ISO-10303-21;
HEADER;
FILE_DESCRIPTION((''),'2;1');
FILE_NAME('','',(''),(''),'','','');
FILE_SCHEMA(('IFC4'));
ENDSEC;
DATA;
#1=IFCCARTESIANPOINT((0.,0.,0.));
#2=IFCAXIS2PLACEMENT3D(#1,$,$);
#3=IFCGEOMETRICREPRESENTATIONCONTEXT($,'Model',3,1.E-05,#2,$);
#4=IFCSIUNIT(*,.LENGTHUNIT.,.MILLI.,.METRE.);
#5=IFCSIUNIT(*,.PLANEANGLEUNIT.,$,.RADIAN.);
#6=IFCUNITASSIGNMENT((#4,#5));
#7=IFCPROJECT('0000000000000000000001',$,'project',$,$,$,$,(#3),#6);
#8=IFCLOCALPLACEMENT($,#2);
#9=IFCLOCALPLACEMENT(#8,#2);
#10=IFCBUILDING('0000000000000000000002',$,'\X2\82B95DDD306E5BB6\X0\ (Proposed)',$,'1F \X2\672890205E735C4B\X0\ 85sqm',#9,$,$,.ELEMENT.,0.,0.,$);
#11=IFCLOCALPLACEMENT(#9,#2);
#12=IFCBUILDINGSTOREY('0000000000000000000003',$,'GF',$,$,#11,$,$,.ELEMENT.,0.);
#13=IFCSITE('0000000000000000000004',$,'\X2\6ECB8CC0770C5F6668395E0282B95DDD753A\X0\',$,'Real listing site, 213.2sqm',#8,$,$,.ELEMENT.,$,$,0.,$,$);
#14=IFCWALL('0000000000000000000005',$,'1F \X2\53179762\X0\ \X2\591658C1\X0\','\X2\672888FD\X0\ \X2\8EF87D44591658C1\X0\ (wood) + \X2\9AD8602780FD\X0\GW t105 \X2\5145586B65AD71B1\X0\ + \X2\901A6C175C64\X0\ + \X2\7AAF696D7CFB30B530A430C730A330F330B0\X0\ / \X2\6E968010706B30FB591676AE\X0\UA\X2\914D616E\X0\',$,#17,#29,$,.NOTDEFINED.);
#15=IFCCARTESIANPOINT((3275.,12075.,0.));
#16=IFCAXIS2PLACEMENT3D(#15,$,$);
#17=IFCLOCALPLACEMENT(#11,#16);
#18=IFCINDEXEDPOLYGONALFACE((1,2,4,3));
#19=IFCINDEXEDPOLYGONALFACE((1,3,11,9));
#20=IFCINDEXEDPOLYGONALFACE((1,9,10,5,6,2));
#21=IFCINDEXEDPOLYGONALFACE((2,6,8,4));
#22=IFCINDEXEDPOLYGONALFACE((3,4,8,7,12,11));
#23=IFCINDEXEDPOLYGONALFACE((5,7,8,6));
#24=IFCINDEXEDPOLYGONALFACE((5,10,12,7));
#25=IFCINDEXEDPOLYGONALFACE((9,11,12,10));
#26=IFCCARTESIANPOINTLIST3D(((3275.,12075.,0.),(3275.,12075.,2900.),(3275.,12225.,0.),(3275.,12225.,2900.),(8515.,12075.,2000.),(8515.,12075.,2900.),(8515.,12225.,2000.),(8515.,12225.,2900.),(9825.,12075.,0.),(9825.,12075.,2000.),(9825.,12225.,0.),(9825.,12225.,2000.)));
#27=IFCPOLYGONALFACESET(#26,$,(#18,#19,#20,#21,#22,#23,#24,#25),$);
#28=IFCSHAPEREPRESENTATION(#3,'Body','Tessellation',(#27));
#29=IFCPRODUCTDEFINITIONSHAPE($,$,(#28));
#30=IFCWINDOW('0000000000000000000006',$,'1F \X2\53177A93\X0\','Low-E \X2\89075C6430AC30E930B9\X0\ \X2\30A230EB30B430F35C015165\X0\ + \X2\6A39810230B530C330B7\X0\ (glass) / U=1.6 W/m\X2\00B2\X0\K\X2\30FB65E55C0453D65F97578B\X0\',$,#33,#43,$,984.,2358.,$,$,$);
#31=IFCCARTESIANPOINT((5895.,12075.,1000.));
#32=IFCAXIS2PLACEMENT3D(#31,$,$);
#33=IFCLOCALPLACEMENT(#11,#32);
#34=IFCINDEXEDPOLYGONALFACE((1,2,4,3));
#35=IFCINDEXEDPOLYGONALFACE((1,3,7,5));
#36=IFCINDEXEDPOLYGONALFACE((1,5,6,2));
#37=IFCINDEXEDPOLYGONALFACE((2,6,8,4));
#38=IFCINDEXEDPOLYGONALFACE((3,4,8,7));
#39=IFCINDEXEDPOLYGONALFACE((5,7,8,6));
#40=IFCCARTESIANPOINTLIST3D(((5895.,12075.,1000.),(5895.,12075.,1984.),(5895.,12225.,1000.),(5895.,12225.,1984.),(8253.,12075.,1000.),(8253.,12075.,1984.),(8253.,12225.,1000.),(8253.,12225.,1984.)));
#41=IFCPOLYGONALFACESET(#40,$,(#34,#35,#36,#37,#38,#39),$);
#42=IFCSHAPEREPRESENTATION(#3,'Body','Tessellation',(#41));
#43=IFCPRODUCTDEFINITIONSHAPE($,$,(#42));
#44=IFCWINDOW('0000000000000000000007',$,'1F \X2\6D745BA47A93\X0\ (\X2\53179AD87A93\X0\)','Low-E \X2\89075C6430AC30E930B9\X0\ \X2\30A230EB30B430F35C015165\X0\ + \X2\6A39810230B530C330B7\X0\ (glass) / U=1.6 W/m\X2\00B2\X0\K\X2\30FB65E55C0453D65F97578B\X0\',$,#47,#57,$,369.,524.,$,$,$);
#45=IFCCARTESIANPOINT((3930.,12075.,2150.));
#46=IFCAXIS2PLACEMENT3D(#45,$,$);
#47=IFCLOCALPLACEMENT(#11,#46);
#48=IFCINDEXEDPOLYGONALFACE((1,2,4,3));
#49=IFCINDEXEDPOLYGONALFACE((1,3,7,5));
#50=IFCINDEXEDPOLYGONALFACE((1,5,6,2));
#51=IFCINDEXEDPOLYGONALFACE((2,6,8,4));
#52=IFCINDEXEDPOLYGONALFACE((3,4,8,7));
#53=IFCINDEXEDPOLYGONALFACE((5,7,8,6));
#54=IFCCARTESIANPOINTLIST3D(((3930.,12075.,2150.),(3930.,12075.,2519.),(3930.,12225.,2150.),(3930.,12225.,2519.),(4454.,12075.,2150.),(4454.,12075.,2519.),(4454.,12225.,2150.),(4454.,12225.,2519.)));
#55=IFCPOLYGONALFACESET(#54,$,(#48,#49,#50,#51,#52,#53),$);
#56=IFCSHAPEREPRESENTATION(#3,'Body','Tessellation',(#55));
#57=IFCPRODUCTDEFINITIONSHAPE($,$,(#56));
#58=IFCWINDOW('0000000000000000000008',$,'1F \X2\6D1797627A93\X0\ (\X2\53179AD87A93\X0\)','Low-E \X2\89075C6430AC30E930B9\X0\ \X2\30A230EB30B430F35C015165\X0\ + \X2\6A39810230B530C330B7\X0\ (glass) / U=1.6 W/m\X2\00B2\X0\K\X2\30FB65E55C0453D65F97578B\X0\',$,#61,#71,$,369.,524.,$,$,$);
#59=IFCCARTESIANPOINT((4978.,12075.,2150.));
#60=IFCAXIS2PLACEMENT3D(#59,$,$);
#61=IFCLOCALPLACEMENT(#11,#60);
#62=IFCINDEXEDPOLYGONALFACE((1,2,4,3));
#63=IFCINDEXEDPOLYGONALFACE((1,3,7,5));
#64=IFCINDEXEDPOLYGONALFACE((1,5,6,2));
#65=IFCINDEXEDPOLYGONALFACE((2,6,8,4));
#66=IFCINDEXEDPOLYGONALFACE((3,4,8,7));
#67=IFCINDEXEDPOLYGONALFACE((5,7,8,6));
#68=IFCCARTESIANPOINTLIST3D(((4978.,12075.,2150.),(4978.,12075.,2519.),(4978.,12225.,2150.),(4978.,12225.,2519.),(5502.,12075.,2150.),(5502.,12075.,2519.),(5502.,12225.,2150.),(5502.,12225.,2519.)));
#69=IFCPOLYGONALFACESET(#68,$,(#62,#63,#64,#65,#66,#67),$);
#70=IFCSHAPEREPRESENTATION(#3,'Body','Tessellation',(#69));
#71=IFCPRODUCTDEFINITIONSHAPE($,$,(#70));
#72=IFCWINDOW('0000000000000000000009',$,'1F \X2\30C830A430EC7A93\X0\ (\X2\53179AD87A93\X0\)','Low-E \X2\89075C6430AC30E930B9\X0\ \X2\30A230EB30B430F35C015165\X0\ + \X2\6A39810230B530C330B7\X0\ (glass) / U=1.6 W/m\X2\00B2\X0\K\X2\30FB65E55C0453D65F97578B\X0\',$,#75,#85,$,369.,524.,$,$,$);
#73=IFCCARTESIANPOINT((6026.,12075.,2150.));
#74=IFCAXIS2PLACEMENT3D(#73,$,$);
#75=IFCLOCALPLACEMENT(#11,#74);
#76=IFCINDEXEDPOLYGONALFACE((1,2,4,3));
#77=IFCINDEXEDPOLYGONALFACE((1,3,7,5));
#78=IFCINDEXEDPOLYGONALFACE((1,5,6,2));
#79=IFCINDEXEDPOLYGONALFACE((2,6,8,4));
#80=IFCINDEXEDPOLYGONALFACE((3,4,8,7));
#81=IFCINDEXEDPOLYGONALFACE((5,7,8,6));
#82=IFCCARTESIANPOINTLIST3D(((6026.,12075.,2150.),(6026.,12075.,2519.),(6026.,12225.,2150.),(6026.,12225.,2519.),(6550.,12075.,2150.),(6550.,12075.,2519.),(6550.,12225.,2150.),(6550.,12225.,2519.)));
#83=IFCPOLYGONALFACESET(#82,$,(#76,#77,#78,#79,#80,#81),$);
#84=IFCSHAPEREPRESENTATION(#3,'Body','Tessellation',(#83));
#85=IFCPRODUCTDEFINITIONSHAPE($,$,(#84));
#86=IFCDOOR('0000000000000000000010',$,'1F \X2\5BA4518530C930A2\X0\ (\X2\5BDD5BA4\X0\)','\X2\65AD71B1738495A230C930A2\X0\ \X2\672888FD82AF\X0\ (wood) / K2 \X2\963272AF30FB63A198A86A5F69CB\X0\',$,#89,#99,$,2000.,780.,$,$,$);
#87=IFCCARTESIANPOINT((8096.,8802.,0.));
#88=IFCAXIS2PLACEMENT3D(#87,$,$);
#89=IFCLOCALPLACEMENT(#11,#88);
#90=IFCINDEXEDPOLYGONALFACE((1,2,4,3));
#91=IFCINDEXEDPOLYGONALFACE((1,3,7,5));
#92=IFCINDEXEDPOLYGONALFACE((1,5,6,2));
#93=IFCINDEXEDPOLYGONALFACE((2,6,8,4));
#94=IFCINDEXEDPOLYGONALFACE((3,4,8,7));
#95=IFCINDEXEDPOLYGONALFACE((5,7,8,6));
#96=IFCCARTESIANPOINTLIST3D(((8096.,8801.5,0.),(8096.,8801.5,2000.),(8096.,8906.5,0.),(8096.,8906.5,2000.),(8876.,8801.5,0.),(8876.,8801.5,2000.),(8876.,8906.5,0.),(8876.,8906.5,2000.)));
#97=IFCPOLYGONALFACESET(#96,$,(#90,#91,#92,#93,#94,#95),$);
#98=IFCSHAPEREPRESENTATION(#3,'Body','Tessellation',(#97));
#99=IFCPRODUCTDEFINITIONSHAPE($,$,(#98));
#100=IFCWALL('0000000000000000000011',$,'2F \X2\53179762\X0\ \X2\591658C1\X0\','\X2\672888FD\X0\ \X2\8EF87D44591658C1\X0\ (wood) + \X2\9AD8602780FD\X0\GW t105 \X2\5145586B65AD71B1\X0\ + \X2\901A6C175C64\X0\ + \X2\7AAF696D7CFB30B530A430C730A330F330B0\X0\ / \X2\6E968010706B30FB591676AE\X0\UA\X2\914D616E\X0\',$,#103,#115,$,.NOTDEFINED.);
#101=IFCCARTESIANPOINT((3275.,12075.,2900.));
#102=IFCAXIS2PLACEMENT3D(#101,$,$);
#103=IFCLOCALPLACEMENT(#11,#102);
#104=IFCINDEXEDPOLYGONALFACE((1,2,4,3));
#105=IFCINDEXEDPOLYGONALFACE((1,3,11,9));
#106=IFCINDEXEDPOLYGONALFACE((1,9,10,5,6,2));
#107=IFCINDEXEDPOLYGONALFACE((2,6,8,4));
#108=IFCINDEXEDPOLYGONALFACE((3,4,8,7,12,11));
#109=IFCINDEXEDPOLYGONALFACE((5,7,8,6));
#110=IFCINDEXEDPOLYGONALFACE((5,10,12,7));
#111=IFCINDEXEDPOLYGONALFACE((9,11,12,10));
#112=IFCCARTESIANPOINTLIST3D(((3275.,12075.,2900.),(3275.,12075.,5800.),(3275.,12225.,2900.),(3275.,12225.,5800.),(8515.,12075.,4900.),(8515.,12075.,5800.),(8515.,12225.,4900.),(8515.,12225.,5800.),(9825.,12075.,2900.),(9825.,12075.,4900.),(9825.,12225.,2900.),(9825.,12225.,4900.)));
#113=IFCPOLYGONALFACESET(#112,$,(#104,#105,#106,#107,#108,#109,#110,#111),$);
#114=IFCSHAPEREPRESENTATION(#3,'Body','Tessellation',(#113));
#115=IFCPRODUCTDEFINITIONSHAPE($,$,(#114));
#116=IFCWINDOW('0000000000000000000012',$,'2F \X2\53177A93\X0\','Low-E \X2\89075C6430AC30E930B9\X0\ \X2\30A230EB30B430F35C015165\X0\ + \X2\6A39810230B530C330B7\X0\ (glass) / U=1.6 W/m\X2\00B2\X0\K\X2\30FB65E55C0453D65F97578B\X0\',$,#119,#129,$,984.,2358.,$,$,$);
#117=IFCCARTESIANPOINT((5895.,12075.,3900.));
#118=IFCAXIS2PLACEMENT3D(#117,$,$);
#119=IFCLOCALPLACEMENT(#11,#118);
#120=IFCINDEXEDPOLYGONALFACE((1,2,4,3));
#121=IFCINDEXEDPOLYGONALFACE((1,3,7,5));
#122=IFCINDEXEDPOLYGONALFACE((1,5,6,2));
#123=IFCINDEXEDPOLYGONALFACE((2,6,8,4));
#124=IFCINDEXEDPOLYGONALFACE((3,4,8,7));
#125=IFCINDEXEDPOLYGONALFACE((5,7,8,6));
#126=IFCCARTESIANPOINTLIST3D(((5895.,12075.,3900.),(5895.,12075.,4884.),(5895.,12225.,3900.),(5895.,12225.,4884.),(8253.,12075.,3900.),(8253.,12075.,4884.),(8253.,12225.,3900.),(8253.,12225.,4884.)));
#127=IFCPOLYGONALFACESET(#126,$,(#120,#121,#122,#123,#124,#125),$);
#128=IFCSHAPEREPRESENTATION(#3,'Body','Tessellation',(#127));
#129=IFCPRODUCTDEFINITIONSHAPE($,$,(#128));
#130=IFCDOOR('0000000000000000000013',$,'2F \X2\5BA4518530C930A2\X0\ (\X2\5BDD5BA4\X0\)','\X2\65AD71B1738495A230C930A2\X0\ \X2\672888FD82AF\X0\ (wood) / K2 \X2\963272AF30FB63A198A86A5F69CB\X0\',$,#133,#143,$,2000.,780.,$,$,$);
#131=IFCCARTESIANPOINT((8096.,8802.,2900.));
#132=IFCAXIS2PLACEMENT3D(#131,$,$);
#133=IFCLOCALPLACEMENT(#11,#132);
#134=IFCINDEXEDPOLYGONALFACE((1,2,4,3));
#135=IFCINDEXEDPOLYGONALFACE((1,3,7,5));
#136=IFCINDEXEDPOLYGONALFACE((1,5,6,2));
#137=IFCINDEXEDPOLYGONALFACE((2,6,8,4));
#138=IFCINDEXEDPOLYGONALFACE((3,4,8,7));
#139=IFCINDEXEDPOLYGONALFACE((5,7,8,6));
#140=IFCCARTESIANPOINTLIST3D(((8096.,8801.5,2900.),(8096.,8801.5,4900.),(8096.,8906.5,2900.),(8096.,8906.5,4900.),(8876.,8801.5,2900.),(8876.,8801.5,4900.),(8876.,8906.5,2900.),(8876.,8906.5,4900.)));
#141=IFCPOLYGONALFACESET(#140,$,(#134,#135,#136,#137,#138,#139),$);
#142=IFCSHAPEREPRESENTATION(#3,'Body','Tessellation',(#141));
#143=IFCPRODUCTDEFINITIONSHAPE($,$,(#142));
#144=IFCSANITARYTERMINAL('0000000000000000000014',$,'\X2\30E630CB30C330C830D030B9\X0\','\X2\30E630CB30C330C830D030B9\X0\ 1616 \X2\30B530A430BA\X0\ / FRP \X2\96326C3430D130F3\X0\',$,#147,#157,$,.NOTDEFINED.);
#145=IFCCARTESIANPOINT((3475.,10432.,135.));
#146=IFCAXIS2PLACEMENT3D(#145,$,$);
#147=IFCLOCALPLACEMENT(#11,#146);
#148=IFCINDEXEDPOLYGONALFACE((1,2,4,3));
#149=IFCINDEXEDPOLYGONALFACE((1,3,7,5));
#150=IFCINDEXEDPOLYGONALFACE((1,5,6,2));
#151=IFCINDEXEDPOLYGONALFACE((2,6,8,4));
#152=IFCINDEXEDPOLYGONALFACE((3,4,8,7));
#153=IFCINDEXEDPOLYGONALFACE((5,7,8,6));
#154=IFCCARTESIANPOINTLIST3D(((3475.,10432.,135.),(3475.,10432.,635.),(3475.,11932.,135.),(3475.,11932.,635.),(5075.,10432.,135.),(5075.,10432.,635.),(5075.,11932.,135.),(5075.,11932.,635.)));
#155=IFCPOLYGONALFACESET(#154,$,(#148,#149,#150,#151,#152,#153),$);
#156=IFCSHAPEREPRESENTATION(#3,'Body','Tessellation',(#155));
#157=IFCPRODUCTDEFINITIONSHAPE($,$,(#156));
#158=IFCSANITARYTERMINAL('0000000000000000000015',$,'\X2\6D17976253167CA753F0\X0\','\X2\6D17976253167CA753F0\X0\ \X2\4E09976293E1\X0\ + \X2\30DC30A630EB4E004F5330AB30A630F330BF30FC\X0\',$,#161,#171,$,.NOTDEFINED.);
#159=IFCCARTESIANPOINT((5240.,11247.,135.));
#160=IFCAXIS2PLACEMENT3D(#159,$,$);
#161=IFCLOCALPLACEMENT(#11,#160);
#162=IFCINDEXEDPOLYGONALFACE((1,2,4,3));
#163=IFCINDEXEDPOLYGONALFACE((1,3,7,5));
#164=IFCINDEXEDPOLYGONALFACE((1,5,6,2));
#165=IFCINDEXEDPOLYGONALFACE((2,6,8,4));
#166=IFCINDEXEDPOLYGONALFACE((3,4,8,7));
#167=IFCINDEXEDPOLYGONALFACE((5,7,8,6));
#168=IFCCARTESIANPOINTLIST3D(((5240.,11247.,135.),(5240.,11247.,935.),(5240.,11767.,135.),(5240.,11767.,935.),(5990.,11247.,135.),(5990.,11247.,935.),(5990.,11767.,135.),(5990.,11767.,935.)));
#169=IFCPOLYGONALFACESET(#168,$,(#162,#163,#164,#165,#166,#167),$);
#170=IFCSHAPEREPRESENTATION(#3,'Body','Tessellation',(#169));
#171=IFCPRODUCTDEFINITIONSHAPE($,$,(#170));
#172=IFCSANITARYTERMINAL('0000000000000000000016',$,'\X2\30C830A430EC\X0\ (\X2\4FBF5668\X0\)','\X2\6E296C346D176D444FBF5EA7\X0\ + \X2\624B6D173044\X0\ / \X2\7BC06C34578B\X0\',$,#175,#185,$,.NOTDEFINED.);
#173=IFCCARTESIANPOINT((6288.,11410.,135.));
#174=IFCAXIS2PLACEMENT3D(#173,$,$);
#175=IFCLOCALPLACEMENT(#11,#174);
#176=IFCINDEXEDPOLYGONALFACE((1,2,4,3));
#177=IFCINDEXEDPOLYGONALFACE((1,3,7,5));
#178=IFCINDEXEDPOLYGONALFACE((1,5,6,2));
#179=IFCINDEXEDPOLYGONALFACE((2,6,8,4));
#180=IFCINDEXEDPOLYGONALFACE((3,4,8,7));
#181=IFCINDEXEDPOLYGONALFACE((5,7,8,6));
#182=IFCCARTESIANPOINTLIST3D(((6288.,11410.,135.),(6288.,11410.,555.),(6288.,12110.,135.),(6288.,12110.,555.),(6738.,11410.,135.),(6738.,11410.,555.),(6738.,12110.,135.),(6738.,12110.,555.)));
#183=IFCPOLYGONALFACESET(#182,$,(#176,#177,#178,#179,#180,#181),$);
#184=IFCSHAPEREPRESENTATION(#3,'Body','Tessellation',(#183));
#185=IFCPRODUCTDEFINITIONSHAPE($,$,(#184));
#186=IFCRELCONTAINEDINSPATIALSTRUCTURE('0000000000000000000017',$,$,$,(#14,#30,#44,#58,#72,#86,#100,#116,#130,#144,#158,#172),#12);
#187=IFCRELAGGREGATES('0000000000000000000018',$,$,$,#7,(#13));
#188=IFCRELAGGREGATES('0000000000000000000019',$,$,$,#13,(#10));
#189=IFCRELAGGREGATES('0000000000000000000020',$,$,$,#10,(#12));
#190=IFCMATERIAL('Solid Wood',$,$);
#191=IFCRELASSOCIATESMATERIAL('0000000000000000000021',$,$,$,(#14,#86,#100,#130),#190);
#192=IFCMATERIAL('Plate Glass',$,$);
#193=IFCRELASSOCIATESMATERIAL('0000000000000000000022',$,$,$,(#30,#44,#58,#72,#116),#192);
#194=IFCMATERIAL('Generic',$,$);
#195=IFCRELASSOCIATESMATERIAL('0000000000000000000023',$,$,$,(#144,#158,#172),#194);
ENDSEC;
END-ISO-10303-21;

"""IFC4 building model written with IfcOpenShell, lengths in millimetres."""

from ifc_helpers import new_model, si_unit, frame, frame_2d, origin, place, context, project, spatial, rectangle, extrude, material, element, fill, save


model = new_model("IFC4")

# Units and contexts
model_context = context("Model", 3, precision=1e-05, world=origin())
ifc_project = project(units=[si_unit("LENGTHUNIT", "METRE", prefix="MILLI"), si_unit("PLANEANGLEUNIT", "RADIAN")], contexts=[model_context])

# Site, building, storey
site_placement = place(None, origin())
site = spatial("IfcSite", under=ifc_project, at=site_placement, Name="滋賀県彦根市芹川町", ObjectType="Real listing site, 213.2sqm", CompositionType="ELEMENT", RefElevation=0.0)
building_placement = place(site_placement, origin())
building = spatial("IfcBuilding", under=site, at=building_placement, Name="芹川の家 (Proposed)", ObjectType="1F 木造平屋 85sqm", CompositionType="ELEMENT", ElevationOfRefHeight=0.0, ElevationOfTerrain=0.0)
storey_placement = place(building_placement, origin())
storey = spatial("IfcBuildingStorey", under=building, at=storey_placement, Name="GF", CompositionType="ELEMENT", Elevation=0.0)

# Wall, openings, windows
ifc_material_1 = material(Name="Solid Wood")
wall_1_placement = place(storey_placement, frame((3275.0, 12075.0, 0.0)))
wall_1 = element("IfcWall", 1, at=wall_1_placement, inside=storey, material=ifc_material_1, Name="1F 北面 外壁", Description="木製 軸組外壁 (wood) + 高性能GW t105 充填断熱 + 通気層 + 窯業系サイディング / 準耐火・外皮UA配慮", PredefinedType="NOTDEFINED", context=model_context, shape_type="SweptSolid", body=[
    extrude(rectangle(XDim=6550.0, YDim=150.0, at=frame_2d((3275.0, 75.0))), frame((3275.0, 12075.0, 0.0)), (0.0, 0.0, 1.0), 2900.0),
])
opening_1_placement = place(storey_placement, frame((5895.0, 12075.0, 1000.0)))
opening_1 = element("IfcOpeningElement", 2, at=opening_1_placement, cuts=wall_1, PredefinedType="NOTDEFINED", context=model_context, shape_type="SweptSolid", body=[
    extrude(rectangle(XDim=2358.0, YDim=150.0, at=frame_2d((1179.0, 75.0))), frame((5895.0, 12075.0, 1000.0)), (0.0, 0.0, 1.0), 984.0),
])
opening_2_placement = place(storey_placement, frame((3930.0, 12075.0, 2150.0)))
opening_2 = element("IfcOpeningElement", 3, at=opening_2_placement, cuts=wall_1, PredefinedType="NOTDEFINED", context=model_context, shape_type="SweptSolid", body=[
    extrude(rectangle(XDim=524.0, YDim=150.0, at=frame_2d((262.0, 75.0))), frame((3930.0, 12075.0, 2150.0)), (0.0, 0.0, 1.0), 369.0),
])
opening_3_placement = place(storey_placement, frame((4978.0, 12075.0, 2150.0)))
opening_3 = element("IfcOpeningElement", 4, at=opening_3_placement, cuts=wall_1, PredefinedType="NOTDEFINED", context=model_context, shape_type="SweptSolid", body=[
    extrude(rectangle(XDim=524.0, YDim=150.0, at=frame_2d((262.0, 75.0))), frame((4978.0, 12075.0, 2150.0)), (0.0, 0.0, 1.0), 369.0),
])
opening_4_placement = place(storey_placement, frame((6026.0, 12075.0, 2150.0)))
opening_4 = element("IfcOpeningElement", 5, at=opening_4_placement, cuts=wall_1, PredefinedType="NOTDEFINED", context=model_context, shape_type="SweptSolid", body=[
    extrude(rectangle(XDim=524.0, YDim=150.0, at=frame_2d((262.0, 75.0))), frame((6026.0, 12075.0, 2150.0)), (0.0, 0.0, 1.0), 369.0),
])
ifc_material_2 = material(Name="Plate Glass")
window_1_placement = place(storey_placement, frame((5895.0, 12075.0, 1000.0)))
window_1 = element("IfcWindow", 6, at=window_1_placement, inside=storey, material=ifc_material_2, Name="1F 北窓", Description="Low-E 複層ガラス アルゴン封入 + 樹脂サッシ (glass) / U=1.6 W/m²K・日射取得型", OverallHeight=984.0, OverallWidth=2358.0, context=model_context, shape_type="SweptSolid", body=[
    extrude(rectangle(XDim=2358.0, YDim=150.0, at=frame_2d((1179.0, 75.0))), frame((5895.0, 12075.0, 1000.0)), (0.0, 0.0, 1.0), 984.0),
])
fill(opening_1, window_1)
window_2_placement = place(storey_placement, frame((3930.0, 12075.0, 2150.0)))
window_2 = element("IfcWindow", 7, at=window_2_placement, inside=storey, material=ifc_material_2, Name="1F 浴室窓 (北高窓)", Description="Low-E 複層ガラス アルゴン封入 + 樹脂サッシ (glass) / U=1.6 W/m²K・日射取得型", OverallHeight=369.0, OverallWidth=524.0, context=model_context, shape_type="SweptSolid", body=[
    extrude(rectangle(XDim=524.0, YDim=150.0, at=frame_2d((262.0, 75.0))), frame((3930.0, 12075.0, 2150.0)), (0.0, 0.0, 1.0), 369.0),
])
fill(opening_2, window_2)
window_3_placement = place(storey_placement, frame((4978.0, 12075.0, 2150.0)))
window_3 = element("IfcWindow", 8, at=window_3_placement, inside=storey, material=ifc_material_2, Name="1F 洗面窓 (北高窓)", Description="Low-E 複層ガラス アルゴン封入 + 樹脂サッシ (glass) / U=1.6 W/m²K・日射取得型", OverallHeight=369.0, OverallWidth=524.0, context=model_context, shape_type="SweptSolid", body=[
    extrude(rectangle(XDim=524.0, YDim=150.0, at=frame_2d((262.0, 75.0))), frame((4978.0, 12075.0, 2150.0)), (0.0, 0.0, 1.0), 369.0),
])
fill(opening_3, window_3)
window_4_placement = place(storey_placement, frame((6026.0, 12075.0, 2150.0)))
window_4 = element("IfcWindow", 9, at=window_4_placement, inside=storey, material=ifc_material_2, Name="1F トイレ窓 (北高窓)", Description="Low-E 複層ガラス アルゴン封入 + 樹脂サッシ (glass) / U=1.6 W/m²K・日射取得型", OverallHeight=369.0, OverallWidth=524.0, context=model_context, shape_type="SweptSolid", body=[
    extrude(rectangle(XDim=524.0, YDim=150.0, at=frame_2d((262.0, 75.0))), frame((6026.0, 12075.0, 2150.0)), (0.0, 0.0, 1.0), 369.0),
])
fill(opening_4, window_4)

# Door
door_1_placement = place(storey_placement, frame((8096.0, 8802.0, 0.0)))
element("IfcDoor", 10, at=door_1_placement, inside=storey, material=ifc_material_1, Name="1F 室内ドア (寝室)", Description="断熱玄関ドア 木製芯 (wood) / K2 防犯・採風機構", OverallHeight=2000.0, OverallWidth=780.0, context=model_context, shape_type="SweptSolid", body=[
    extrude(rectangle(XDim=780.0, YDim=105.0, at=frame_2d((390.0, 52.0))), frame((8096.0, 8802.0, 0.0)), (0.0, 0.0, 1.0), 2000.0),
])

# Wall, opening, window
wall_2_placement = place(storey_placement, frame((3275.0, 12075.0, 2900.0)))
wall_2 = element("IfcWall", 11, at=wall_2_placement, inside=storey, material=ifc_material_1, Name="2F 北面 外壁", Description="木製 軸組外壁 (wood) + 高性能GW t105 充填断熱 + 通気層 + 窯業系サイディング / 準耐火・外皮UA配慮", PredefinedType="NOTDEFINED", context=model_context, shape_type="SweptSolid", body=[
    extrude(rectangle(XDim=6550.0, YDim=150.0, at=frame_2d((3275.0, 75.0))), frame((3275.0, 12075.0, 2900.0)), (0.0, 0.0, 1.0), 2900.0),
])
opening_5_placement = place(storey_placement, frame((5895.0, 12075.0, 3900.0)))
opening_5 = element("IfcOpeningElement", 12, at=opening_5_placement, cuts=wall_2, PredefinedType="NOTDEFINED", context=model_context, shape_type="SweptSolid", body=[
    extrude(rectangle(XDim=2358.0, YDim=150.0, at=frame_2d((1179.0, 75.0))), frame((5895.0, 12075.0, 3900.0)), (0.0, 0.0, 1.0), 984.0),
])
window_5_placement = place(storey_placement, frame((5895.0, 12075.0, 3900.0)))
window_5 = element("IfcWindow", 13, at=window_5_placement, inside=storey, material=ifc_material_2, Name="2F 北窓", Description="Low-E 複層ガラス アルゴン封入 + 樹脂サッシ (glass) / U=1.6 W/m²K・日射取得型", OverallHeight=984.0, OverallWidth=2358.0, context=model_context, shape_type="SweptSolid", body=[
    extrude(rectangle(XDim=2358.0, YDim=150.0, at=frame_2d((1179.0, 75.0))), frame((5895.0, 12075.0, 3900.0)), (0.0, 0.0, 1.0), 984.0),
])
fill(opening_5, window_5)

# Door
door_2_placement = place(storey_placement, frame((8096.0, 8802.0, 2900.0)))
element("IfcDoor", 14, at=door_2_placement, inside=storey, material=ifc_material_1, Name="2F 室内ドア (寝室)", Description="断熱玄関ドア 木製芯 (wood) / K2 防犯・採風機構", OverallHeight=2000.0, OverallWidth=780.0, context=model_context, shape_type="SweptSolid", body=[
    extrude(rectangle(XDim=780.0, YDim=105.0, at=frame_2d((390.0, 52.0))), frame((8096.0, 8802.0, 2900.0)), (0.0, 0.0, 1.0), 2000.0),
])

# Sanitary terminals
ifc_material_3 = material(Name="Generic")
sanitary_terminal_1_placement = place(storey_placement, frame((3475.0, 10432.0, 135.0)))
element("IfcSanitaryTerminal", 15, at=sanitary_terminal_1_placement, inside=storey, material=ifc_material_3, Name="ユニットバス", Description="ユニットバス 1616 サイズ / FRP 防水パン", PredefinedType="NOTDEFINED", context=model_context, shape_type="SweptSolid", body=[
    extrude(rectangle(XDim=1600.0, YDim=1500.0, at=frame_2d((800.0, 750.0))), frame((3475.0, 10432.0, 135.0)), (0.0, 0.0, 1.0), 500.0),
])
sanitary_terminal_2_placement = place(storey_placement, frame((5240.0, 11247.0, 135.0)))
element("IfcSanitaryTerminal", 16, at=sanitary_terminal_2_placement, inside=storey, material=ifc_material_3, Name="洗面化粧台", Description="洗面化粧台 三面鏡 + ボウル一体カウンター", PredefinedType="NOTDEFINED", context=model_context, shape_type="SweptSolid", body=[
    extrude(rectangle(XDim=750.0, YDim=520.0, at=frame_2d((375.0, 260.0))), frame((5240.0, 11247.0, 135.0)), (0.0, 0.0, 1.0), 800.0),
])
sanitary_terminal_3_placement = place(storey_placement, frame((6288.0, 11410.0, 135.0)))
element("IfcSanitaryTerminal", 17, at=sanitary_terminal_3_placement, inside=storey, material=ifc_material_3, Name="トイレ (便器)", Description="温水洗浄便座 + 手洗い / 節水型", PredefinedType="NOTDEFINED", context=model_context, shape_type="SweptSolid", body=[
    extrude(rectangle(XDim=450.0, YDim=700.0, at=frame_2d((225.0, 350.0))), frame((6288.0, 11410.0, 135.0)), (0.0, 0.0, 1.0), 420.0),
])

save(model, "model.ifc")
